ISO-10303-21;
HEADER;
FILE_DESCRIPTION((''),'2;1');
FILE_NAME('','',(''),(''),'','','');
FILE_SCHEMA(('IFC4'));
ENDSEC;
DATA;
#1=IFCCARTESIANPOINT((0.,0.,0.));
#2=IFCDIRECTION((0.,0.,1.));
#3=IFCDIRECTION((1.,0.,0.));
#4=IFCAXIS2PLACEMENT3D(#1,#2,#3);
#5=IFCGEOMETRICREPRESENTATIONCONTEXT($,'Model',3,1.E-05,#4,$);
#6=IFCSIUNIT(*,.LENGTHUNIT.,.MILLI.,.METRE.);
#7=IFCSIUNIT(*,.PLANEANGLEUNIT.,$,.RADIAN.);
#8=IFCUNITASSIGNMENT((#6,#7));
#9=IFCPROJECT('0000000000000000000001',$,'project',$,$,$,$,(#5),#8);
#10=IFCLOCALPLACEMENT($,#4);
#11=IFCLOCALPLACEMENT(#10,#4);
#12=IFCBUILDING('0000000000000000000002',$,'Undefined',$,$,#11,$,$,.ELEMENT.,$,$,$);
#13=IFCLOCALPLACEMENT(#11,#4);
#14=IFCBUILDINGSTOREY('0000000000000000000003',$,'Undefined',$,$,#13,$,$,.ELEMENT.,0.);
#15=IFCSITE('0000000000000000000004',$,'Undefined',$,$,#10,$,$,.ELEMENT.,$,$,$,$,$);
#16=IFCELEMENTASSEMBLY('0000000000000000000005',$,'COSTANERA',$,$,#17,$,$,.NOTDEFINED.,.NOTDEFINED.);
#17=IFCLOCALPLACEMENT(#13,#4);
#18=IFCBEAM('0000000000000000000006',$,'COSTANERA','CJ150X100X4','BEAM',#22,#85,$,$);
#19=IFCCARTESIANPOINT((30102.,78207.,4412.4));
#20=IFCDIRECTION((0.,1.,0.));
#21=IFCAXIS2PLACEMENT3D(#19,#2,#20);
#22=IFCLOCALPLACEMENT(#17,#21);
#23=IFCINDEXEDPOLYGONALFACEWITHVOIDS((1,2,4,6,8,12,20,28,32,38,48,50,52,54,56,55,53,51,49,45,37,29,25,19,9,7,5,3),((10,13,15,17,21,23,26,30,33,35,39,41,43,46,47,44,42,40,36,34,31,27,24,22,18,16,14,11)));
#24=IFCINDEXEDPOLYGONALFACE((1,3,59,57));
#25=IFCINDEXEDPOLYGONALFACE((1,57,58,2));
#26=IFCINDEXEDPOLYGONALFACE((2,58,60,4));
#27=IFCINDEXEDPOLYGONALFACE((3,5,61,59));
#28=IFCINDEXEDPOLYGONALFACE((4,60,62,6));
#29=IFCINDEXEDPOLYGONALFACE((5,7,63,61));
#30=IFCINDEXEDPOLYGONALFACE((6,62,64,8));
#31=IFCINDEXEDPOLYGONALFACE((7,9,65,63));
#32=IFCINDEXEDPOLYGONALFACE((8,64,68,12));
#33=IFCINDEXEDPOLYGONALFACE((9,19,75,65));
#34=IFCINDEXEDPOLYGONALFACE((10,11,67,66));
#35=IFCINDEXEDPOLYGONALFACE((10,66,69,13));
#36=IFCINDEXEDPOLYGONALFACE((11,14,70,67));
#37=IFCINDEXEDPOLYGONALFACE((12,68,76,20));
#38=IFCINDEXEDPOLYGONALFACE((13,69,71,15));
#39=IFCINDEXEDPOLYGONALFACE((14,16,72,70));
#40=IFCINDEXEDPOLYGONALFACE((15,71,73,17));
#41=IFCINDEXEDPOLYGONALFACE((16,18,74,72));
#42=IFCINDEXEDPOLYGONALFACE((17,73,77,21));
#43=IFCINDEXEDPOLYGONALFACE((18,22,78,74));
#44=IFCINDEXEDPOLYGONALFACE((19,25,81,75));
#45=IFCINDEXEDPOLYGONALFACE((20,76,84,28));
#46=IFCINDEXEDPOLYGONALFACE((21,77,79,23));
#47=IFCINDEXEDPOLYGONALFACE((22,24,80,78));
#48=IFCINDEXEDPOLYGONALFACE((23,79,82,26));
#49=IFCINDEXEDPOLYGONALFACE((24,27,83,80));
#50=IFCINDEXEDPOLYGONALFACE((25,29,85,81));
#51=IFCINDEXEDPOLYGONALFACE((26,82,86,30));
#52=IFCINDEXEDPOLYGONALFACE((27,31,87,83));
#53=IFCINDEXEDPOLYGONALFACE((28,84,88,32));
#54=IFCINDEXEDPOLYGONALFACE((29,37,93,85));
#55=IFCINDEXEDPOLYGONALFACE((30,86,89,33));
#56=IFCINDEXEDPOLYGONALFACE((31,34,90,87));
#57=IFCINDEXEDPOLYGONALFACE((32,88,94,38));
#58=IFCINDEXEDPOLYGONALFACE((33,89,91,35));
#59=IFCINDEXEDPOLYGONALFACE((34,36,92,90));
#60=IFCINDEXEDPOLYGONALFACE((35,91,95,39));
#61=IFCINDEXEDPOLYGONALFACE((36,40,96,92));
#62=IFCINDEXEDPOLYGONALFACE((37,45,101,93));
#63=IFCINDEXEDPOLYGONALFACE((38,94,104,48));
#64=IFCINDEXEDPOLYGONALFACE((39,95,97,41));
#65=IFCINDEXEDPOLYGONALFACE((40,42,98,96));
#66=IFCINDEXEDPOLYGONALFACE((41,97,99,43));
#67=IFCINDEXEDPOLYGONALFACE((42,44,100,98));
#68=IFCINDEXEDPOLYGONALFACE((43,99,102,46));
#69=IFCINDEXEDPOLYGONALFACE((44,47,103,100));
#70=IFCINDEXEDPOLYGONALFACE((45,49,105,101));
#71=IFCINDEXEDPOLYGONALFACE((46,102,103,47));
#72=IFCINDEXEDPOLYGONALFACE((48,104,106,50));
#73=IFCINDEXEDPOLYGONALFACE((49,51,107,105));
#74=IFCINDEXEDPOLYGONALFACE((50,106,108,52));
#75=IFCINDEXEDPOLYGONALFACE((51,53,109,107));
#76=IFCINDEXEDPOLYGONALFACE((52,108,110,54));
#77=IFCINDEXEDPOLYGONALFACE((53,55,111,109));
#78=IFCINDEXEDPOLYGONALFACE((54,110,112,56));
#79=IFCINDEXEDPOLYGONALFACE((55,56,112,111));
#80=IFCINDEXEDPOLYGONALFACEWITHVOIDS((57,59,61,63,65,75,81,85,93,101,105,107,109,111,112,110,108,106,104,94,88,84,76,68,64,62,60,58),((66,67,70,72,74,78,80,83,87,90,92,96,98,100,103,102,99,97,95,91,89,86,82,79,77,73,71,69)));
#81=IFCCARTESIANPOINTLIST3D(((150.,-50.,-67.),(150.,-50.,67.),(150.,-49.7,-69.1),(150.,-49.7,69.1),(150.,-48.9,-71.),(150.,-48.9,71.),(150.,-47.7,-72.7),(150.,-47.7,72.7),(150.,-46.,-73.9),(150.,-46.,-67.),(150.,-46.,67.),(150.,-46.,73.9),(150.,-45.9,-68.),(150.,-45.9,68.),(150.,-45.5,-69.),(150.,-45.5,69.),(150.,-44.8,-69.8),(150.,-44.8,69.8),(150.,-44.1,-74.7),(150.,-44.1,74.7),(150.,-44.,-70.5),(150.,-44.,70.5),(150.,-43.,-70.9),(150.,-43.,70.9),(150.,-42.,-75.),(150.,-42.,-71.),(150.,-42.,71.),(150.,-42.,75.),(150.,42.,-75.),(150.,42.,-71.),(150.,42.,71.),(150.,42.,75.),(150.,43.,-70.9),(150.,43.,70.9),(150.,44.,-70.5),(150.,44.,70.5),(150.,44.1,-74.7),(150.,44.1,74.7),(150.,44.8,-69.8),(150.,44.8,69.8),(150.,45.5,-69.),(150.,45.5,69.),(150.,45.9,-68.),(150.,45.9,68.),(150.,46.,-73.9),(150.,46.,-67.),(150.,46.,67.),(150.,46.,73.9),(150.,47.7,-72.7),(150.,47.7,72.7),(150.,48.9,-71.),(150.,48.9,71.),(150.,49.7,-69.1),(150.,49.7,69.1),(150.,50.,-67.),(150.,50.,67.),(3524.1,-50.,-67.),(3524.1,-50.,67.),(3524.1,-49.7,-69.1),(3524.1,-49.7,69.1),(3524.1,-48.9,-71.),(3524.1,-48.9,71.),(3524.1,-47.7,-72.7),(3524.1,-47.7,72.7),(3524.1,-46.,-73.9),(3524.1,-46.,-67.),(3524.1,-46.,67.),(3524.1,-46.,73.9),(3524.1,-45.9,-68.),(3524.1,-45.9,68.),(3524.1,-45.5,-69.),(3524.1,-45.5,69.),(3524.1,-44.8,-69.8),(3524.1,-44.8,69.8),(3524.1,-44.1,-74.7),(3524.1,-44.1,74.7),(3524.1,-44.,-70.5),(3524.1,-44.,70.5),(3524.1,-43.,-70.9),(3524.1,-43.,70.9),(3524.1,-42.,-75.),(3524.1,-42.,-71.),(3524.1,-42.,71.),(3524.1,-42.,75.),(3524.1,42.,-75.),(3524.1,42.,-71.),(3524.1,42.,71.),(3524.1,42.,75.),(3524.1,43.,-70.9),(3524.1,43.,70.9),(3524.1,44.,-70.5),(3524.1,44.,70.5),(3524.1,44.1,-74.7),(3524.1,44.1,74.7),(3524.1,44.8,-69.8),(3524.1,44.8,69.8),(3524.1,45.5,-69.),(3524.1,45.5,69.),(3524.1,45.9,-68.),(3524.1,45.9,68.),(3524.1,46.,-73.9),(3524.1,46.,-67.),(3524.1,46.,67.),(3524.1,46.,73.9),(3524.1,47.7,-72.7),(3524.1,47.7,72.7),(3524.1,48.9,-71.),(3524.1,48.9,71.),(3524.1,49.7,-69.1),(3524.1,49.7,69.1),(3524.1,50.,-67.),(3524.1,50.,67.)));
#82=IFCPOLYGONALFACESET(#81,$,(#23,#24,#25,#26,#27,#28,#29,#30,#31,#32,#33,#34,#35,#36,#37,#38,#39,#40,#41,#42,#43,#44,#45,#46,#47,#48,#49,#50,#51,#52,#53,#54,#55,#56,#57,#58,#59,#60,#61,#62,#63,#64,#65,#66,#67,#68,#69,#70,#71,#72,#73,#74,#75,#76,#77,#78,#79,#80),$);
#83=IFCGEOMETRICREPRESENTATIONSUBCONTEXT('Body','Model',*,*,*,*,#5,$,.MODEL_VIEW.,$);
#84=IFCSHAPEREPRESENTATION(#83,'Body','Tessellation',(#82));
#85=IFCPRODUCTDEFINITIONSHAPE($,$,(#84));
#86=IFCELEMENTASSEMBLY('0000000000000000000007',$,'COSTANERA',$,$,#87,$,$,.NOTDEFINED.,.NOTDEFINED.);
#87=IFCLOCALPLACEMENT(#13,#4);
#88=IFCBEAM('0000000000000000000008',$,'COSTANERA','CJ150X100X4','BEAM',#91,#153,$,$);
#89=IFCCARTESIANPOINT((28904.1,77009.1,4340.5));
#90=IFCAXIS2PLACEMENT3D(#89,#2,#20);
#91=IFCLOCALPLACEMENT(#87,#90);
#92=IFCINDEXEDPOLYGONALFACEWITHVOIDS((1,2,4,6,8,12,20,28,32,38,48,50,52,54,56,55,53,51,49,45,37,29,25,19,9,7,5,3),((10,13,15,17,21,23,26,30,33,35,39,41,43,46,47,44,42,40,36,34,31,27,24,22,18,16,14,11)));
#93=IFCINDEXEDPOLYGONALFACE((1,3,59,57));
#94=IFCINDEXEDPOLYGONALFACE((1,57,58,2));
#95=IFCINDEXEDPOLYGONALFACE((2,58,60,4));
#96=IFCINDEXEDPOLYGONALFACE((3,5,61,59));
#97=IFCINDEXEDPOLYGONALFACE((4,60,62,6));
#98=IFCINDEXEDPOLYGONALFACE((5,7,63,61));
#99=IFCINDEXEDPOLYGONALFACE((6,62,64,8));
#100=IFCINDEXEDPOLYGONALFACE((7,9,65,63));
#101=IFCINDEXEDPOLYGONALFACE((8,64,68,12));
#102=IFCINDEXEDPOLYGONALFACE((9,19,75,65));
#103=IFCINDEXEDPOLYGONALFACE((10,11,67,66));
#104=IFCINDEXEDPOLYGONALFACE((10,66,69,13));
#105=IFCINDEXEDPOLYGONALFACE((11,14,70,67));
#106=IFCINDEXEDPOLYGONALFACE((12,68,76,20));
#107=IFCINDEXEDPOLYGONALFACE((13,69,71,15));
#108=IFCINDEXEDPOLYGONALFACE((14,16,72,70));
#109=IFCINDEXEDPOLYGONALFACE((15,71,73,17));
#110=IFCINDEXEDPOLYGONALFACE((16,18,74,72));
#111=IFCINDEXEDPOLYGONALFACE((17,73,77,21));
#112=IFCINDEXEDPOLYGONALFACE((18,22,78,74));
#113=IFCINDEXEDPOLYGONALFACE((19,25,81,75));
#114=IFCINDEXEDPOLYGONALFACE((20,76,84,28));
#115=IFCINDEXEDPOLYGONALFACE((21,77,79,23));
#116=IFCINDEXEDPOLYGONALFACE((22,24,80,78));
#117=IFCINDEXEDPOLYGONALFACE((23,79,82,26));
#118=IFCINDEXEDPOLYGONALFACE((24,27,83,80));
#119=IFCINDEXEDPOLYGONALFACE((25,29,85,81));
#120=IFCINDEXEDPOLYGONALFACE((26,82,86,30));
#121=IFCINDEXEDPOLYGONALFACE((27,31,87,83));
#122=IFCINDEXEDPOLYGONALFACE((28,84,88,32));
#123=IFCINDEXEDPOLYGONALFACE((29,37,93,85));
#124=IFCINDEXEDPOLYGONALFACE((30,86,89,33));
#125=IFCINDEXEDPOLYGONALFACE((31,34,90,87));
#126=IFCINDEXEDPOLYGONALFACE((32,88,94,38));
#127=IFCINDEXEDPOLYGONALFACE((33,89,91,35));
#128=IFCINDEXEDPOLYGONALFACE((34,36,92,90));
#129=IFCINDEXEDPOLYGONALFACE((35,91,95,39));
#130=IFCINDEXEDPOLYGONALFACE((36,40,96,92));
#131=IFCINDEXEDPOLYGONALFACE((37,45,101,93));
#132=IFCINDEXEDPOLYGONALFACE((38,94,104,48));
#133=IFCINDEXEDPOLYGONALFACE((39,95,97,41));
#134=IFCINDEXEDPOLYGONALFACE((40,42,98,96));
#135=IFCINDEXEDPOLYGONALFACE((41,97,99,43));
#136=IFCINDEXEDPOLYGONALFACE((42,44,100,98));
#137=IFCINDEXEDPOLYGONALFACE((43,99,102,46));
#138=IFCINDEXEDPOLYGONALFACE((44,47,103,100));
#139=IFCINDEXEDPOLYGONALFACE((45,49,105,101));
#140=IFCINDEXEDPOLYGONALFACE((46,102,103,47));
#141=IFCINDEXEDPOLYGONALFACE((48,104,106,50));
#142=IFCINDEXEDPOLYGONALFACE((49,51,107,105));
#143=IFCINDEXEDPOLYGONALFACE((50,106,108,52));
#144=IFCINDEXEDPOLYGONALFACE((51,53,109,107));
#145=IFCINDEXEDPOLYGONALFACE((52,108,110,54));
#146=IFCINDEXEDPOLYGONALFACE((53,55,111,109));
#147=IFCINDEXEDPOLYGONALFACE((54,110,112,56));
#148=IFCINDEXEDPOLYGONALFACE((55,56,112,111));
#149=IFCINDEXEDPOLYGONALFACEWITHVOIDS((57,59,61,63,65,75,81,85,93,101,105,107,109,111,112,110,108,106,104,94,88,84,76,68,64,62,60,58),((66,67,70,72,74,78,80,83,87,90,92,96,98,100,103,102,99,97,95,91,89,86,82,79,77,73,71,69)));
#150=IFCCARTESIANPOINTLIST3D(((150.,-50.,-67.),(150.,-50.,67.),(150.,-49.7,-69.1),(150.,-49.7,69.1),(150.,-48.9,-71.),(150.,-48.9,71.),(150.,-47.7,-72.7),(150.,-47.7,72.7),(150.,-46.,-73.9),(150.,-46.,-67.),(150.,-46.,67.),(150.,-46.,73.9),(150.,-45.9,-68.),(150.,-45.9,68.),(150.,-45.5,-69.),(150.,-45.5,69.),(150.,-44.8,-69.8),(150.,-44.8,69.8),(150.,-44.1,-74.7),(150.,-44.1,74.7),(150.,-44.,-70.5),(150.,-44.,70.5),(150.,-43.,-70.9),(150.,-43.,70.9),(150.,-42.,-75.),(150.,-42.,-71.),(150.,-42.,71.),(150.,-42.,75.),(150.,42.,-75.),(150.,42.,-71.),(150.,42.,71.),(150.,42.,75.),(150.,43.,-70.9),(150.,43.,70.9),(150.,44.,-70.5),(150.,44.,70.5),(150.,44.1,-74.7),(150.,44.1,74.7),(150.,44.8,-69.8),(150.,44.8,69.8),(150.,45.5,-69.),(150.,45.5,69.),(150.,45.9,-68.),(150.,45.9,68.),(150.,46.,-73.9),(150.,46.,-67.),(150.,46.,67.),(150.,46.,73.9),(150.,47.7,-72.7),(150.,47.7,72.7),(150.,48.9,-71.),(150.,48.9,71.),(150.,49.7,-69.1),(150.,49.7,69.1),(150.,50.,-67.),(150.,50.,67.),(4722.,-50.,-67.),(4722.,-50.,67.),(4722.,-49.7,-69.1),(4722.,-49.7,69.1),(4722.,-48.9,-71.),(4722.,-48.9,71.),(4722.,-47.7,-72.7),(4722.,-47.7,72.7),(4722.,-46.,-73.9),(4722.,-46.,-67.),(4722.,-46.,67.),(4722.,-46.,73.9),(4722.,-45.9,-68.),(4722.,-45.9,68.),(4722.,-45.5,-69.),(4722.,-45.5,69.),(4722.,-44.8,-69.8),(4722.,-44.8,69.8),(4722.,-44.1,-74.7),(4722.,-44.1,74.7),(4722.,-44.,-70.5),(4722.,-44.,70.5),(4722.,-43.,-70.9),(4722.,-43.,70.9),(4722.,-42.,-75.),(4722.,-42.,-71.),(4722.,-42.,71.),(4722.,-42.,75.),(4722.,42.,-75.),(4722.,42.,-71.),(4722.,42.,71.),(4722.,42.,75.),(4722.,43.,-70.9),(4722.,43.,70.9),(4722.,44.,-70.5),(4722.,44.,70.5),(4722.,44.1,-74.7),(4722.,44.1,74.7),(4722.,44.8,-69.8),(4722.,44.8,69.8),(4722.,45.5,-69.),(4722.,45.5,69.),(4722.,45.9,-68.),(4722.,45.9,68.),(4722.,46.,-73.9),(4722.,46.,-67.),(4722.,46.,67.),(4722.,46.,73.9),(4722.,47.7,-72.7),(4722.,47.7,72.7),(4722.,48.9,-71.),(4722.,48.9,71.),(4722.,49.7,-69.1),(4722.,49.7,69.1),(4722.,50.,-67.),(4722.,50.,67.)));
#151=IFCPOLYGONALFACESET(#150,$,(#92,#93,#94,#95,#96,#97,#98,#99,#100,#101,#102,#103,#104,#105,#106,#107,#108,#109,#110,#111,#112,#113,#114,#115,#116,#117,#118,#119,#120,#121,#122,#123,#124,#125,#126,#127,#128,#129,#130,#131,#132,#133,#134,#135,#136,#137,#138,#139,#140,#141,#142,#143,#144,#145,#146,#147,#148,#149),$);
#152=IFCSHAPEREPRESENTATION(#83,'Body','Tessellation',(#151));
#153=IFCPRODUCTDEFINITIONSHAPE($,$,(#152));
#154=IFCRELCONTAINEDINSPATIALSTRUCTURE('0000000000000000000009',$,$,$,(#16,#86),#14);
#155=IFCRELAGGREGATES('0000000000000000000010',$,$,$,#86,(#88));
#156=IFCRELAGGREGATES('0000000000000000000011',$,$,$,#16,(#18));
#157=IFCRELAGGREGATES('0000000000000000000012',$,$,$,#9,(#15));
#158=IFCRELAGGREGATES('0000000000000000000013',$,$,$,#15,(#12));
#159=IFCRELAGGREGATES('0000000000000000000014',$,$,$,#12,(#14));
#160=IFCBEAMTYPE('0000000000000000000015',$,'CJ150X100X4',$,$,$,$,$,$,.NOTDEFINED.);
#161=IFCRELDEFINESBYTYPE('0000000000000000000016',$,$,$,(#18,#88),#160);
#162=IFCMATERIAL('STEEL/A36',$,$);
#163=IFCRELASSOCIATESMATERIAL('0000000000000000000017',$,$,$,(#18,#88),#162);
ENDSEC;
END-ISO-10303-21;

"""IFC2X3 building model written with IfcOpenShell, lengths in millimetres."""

from ifc_helpers import new_model, si_unit, frame, origin_with_axes, origin_2d_with_axis, place, context, subcontext, project, spatial, hollow_rectangle, extrude, clip, halfspace, material, type_object, element, aggregate, save


model = new_model("IFC2X3")

# Units and contexts
model_context = context("Model", 3, precision=1e-05, world=origin_with_axes())
body_context = subcontext(model_context, "Body", "Model", "MODEL_VIEW")
ifc_project = project(units=[si_unit("LENGTHUNIT", "METRE", prefix="MILLI"), si_unit("PLANEANGLEUNIT", "RADIAN")], contexts=[model_context])

# Site, building, storey
site_placement = place(None, origin_with_axes())
site = spatial("IfcSite", under=ifc_project, at=site_placement, Name="Undefined", CompositionType="ELEMENT")
building_placement = place(site_placement, origin_with_axes())
building = spatial("IfcBuilding", under=site, at=building_placement, Name="Undefined", CompositionType="ELEMENT")
storey_placement = place(building_placement, origin_with_axes())
storey = spatial("IfcBuildingStorey", under=building, at=storey_placement, Name="Undefined", CompositionType="ELEMENT", Elevation=0.0)

# Shared definitions
ifc_material_1 = material(Name="STEEL/A36")
beam_type = type_object("IfcBeamType", Name="CJ150X100X4", PredefinedType="NOTDEFINED")

# Element assemblies, beams
assembly_1_placement = place(storey_placement, origin_with_axes())
assembly_1 = element("IfcElementAssembly", 1, at=assembly_1_placement, inside=storey, Name="COSTANERA", AssemblyPlace="NOTDEFINED", PredefinedType="NOTDEFINED")
beam_1_placement = place(assembly_1_placement, frame((30102.0, 78207.0, 4412.4), z_axis=(0.0, 0.0, 1.0), x_axis=(0.0, 1.0, 0.0)))
beam_1 = element("IfcBeam", 2, at=beam_1_placement, type_object=beam_type, material=ifc_material_1, Name="COSTANERA", Description="CJ150X100X4", ObjectType="BEAM", context=body_context, shape_type="Clipping", body=[
    clip(extrude(hollow_rectangle(XDim=100.0, YDim=150.0, WallThickness=4.0, InnerFilletRadius=4.0, OuterFilletRadius=8.0, at=origin_2d_with_axis()), frame((3524.1, 0.0, 0.0), z_axis=(-1.0, 0.0, 0.0), x_axis=(0.0, -1.0, 0.0)), (0.0, 0.0, 1.0), 3524.1), halfspace(frame((150.0, -44.8, -480.0), z_axis=(1.0, 0.0, 0.0), x_axis=(0.0, 0.0, 1.0)), True)),
])
assembly_2_placement = place(storey_placement, origin_with_axes())
assembly_2 = element("IfcElementAssembly", 3, at=assembly_2_placement, inside=storey, Name="COSTANERA", AssemblyPlace="NOTDEFINED", PredefinedType="NOTDEFINED")
beam_2_placement = place(assembly_2_placement, frame((28904.1, 77009.1, 4340.5), z_axis=(0.0, 0.0, 1.0), x_axis=(0.0, 1.0, 0.0)))
beam_2 = element("IfcBeam", 4, at=beam_2_placement, type_object=beam_type, material=ifc_material_1, Name="COSTANERA", Description="CJ150X100X4", ObjectType="BEAM", context=body_context, shape_type="Clipping", body=[
    clip(extrude(hollow_rectangle(XDim=100.0, YDim=150.0, WallThickness=4.0, InnerFilletRadius=4.0, OuterFilletRadius=8.0, at=origin_2d_with_axis()), frame((4722.0, 0.0, 0.0), z_axis=(-1.0, 0.0, 0.0), x_axis=(0.0, -1.0, 0.0)), (0.0, 0.0, 1.0), 4722.0), halfspace(frame((150.0, -44.8, -480.0), z_axis=(1.0, 0.0, 0.0), x_axis=(0.0, 0.0, 1.0)), True)),
])

aggregate(assembly_2, [beam_2])
aggregate(assembly_1, [beam_1])

save(model, "model.ifc")
